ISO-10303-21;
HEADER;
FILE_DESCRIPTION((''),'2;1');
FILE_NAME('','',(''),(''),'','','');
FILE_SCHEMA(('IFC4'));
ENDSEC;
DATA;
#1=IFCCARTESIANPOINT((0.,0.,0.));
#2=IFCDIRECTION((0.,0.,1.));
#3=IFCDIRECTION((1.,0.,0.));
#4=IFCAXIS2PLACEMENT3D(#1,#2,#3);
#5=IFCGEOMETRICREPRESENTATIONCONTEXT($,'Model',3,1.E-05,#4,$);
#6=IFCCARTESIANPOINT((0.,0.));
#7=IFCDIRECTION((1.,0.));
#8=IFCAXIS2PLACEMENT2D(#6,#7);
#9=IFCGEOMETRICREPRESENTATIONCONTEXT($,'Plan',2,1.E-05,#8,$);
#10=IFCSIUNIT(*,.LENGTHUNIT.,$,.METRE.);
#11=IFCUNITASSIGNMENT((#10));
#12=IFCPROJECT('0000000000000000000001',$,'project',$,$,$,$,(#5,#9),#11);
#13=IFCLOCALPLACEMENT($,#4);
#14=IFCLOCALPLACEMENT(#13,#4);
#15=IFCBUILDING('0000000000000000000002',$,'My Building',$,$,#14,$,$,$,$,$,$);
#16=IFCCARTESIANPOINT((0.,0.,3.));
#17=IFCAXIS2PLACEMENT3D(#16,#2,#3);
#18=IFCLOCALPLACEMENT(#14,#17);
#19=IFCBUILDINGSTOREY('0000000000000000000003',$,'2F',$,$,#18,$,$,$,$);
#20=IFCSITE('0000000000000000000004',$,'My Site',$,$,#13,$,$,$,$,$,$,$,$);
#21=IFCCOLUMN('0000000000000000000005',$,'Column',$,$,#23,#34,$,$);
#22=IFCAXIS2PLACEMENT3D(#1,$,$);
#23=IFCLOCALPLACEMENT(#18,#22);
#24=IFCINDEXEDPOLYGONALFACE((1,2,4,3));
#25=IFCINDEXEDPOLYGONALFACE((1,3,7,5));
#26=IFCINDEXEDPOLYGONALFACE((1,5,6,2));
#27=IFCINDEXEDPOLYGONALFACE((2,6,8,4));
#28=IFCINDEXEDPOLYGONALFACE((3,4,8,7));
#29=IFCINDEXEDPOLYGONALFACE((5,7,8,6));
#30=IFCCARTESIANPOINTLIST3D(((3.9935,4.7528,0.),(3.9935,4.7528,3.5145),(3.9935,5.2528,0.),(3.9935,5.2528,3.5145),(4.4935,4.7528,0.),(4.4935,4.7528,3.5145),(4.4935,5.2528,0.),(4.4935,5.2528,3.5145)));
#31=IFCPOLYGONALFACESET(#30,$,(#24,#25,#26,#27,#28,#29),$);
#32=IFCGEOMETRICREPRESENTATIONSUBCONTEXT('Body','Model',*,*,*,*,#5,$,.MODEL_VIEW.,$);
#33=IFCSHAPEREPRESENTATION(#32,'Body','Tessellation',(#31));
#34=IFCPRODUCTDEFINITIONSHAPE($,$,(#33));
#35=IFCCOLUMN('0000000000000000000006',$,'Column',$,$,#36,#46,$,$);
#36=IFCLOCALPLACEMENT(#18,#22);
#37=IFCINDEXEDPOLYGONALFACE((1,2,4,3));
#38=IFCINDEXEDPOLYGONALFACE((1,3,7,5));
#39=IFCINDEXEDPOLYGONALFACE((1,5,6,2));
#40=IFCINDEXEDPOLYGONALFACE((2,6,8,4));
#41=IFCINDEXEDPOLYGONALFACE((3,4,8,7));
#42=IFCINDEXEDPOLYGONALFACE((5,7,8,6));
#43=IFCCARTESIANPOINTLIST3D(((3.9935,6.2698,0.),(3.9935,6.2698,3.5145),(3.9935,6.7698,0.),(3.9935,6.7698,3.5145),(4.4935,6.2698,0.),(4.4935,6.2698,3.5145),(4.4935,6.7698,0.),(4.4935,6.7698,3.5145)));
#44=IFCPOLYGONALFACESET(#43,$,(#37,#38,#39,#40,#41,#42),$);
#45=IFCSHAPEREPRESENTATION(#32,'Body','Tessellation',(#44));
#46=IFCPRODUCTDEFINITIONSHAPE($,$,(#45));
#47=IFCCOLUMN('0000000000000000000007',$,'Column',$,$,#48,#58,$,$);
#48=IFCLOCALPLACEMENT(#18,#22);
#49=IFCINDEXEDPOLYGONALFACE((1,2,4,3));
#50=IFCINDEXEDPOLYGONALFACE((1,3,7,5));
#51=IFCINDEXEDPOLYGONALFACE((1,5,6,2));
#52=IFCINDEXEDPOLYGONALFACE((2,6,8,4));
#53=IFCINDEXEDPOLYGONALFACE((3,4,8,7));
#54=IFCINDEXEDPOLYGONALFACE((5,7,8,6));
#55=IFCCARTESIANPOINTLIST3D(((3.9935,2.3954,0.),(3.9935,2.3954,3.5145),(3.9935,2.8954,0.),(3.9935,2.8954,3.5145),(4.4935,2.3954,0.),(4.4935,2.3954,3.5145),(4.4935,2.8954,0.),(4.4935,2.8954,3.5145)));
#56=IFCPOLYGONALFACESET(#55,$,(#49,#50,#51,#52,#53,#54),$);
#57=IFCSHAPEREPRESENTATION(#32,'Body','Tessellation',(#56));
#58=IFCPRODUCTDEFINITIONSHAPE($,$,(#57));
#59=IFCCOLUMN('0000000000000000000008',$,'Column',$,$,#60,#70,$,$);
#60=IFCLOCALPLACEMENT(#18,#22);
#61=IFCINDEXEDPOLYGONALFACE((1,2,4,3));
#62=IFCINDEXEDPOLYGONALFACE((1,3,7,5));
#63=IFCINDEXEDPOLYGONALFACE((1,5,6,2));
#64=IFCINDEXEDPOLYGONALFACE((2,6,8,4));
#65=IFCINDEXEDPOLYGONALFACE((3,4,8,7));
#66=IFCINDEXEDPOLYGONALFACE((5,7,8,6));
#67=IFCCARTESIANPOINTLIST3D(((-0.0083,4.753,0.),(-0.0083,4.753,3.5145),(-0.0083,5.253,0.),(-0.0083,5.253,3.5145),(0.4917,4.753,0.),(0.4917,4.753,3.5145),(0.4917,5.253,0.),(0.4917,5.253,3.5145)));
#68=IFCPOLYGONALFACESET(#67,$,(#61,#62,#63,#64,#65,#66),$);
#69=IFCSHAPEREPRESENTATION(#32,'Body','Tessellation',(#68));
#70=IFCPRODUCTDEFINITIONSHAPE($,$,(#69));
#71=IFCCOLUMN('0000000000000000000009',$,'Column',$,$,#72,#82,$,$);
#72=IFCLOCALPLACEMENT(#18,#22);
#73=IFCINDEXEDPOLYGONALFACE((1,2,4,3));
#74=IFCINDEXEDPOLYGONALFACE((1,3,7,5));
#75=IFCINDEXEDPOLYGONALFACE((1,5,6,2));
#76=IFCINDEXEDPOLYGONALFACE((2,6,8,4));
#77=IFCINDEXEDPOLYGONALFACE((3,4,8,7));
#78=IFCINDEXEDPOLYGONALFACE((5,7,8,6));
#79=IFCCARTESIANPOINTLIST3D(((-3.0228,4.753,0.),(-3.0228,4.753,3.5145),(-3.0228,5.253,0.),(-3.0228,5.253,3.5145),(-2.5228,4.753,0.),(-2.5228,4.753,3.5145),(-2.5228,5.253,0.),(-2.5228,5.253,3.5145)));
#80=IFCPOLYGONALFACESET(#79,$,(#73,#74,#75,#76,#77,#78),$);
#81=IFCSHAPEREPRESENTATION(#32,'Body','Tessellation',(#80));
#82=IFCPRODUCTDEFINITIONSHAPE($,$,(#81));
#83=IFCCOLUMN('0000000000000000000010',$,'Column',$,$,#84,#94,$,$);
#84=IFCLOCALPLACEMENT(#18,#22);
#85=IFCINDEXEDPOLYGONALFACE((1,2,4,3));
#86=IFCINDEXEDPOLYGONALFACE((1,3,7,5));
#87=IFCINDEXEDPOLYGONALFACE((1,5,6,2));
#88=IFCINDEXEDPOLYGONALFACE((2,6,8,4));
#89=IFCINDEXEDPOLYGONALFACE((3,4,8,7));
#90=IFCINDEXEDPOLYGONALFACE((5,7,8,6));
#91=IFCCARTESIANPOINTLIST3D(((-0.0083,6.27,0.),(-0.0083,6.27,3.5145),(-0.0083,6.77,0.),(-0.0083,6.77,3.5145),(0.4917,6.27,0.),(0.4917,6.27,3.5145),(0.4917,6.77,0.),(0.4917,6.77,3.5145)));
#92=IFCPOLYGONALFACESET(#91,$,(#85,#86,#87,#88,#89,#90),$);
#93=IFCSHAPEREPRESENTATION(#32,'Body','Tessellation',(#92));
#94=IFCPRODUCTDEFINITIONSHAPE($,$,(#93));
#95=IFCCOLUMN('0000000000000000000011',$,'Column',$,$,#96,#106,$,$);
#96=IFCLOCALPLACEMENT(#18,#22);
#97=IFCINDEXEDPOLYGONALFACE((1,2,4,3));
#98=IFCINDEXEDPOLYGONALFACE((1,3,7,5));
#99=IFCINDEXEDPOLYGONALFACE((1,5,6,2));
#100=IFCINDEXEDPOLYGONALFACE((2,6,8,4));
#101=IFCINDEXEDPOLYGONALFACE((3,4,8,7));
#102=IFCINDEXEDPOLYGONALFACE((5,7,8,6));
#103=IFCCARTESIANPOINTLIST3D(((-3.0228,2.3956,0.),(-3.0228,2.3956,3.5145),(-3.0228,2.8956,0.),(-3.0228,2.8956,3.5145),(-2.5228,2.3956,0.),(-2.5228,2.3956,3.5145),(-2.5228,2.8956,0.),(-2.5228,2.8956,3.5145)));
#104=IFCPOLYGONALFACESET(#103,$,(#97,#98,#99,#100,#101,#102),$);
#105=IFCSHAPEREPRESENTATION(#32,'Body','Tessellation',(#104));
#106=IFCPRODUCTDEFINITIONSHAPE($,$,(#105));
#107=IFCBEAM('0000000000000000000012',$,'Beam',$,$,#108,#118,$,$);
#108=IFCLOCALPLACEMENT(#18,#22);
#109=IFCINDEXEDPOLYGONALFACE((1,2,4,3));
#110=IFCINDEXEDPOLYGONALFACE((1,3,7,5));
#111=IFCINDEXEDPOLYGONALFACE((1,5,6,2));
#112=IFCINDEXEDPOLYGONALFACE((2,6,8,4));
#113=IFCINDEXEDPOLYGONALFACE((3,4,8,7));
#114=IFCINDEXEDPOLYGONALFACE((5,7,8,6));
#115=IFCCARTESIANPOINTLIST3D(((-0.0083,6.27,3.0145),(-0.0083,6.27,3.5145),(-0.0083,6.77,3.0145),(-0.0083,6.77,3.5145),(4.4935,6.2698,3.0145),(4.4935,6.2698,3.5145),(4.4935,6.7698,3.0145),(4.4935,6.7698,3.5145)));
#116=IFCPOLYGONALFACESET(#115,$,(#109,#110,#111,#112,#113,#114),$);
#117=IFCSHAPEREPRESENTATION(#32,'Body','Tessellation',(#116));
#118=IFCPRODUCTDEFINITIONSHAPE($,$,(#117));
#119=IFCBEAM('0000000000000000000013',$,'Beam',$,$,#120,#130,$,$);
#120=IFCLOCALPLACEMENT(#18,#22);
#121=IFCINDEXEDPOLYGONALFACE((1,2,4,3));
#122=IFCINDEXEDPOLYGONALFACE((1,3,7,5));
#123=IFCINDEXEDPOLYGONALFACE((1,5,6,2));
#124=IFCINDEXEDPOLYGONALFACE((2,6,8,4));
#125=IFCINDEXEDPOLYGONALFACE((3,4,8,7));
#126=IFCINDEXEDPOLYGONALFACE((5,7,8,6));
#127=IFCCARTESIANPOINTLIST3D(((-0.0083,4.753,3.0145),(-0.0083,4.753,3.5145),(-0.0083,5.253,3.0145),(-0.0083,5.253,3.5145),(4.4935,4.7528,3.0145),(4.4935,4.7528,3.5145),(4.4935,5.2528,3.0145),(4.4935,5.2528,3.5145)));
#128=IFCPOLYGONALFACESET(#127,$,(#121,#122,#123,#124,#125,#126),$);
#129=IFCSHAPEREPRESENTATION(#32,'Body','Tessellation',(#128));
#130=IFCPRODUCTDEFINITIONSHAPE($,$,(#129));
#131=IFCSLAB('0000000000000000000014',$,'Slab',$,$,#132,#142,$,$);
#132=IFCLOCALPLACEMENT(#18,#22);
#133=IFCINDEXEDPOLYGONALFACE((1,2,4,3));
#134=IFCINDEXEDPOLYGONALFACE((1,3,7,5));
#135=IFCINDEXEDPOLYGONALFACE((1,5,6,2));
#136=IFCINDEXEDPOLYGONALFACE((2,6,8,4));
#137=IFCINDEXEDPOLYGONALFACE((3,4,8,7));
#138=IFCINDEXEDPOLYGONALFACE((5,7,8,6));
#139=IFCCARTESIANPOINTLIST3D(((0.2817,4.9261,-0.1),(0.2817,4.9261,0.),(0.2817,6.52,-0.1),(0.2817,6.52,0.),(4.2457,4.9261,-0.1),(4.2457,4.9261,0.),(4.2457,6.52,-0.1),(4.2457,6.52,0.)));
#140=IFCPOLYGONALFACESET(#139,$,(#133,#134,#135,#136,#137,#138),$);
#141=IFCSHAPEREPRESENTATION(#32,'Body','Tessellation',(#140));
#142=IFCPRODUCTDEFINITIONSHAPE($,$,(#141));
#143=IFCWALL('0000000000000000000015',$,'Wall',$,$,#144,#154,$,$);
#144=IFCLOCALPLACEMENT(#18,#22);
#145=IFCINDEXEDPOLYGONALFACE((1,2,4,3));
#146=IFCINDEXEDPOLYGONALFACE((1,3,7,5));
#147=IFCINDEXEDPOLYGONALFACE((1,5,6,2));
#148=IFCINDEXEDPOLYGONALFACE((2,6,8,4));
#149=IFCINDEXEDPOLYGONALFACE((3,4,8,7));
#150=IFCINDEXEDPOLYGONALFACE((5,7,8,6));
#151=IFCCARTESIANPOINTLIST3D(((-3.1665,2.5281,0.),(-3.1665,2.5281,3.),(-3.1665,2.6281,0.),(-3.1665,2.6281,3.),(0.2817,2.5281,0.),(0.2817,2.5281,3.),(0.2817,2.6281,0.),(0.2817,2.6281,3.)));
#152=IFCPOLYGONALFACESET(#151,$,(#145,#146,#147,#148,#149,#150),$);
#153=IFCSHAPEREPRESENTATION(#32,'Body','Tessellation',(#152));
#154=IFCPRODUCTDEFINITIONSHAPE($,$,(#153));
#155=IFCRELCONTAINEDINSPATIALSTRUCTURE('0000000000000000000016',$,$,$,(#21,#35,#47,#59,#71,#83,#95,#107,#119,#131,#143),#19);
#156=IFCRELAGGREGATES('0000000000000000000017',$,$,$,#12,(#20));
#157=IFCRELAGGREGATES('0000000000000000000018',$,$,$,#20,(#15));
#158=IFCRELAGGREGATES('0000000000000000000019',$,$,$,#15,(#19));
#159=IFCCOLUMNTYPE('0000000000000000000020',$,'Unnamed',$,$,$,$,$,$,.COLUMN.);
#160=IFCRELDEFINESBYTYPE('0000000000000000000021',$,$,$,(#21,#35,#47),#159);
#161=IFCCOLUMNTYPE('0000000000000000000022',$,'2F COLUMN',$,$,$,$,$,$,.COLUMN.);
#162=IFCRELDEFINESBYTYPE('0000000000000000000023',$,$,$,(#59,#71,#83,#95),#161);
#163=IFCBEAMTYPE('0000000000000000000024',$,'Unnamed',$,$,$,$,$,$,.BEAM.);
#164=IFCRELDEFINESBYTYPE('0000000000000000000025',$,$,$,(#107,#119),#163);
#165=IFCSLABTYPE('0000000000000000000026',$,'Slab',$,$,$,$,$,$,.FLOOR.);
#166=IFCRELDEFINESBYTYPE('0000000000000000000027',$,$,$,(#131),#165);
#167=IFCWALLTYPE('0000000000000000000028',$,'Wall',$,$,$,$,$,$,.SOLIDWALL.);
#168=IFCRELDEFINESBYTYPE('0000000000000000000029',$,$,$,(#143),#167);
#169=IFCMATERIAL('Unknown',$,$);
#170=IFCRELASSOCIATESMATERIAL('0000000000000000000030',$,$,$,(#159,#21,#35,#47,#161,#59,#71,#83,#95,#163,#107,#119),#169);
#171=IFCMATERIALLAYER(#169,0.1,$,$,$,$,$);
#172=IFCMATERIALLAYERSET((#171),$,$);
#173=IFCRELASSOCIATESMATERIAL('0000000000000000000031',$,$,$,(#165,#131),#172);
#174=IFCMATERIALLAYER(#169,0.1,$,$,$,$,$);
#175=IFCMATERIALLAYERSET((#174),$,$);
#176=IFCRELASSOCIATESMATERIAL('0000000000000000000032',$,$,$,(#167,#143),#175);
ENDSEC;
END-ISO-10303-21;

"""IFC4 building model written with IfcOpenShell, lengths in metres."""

from ifc_helpers import new_model, si_unit, frame, origin_with_axes, origin_2d_with_axis, place, context, subcontext, project, spatial, line, indexed_curve, rectangle, outline, extrude, material, layer, layer_set, layer_usage, material_profile, profile_set, profile_usage, type_object, element, save


model = new_model("IFC4")

# Units and contexts
model_context = context("Model", 3, precision=1e-05, world=origin_with_axes())
plan_context = context("Plan", 2, precision=1e-05, world=origin_2d_with_axis())
body_context_1 = subcontext(model_context, "Body", "Model", "MODEL_VIEW")
ifc_project = project(units=[si_unit("LENGTHUNIT", "METRE")], contexts=[model_context, plan_context])

# Site, building, storey
site_placement = place(None, origin_with_axes())
site = spatial("IfcSite", under=ifc_project, at=site_placement, Name="My Site")
building_placement = place(site_placement, origin_with_axes())
building = spatial("IfcBuilding", under=site, at=building_placement, Name="My Building")
storey_placement = place(building_placement, frame((0.0, 0.0, 3.0), z_axis=(0.0, 0.0, 1.0), x_axis=(1.0, 0.0, 0.0)))
storey = spatial("IfcBuildingStorey", under=building, at=storey_placement, Name="2F")

# Columns
ifc_material = material(Name="Unknown")
ifc_material_profile_1 = material_profile(ifc_material, rectangle(XDim=0.5, YDim=0.5))
ifc_profile_set_1 = profile_set([ifc_material_profile_1])
ifc_profile_usage_1 = profile_usage(ifc_profile_set_1, cardinal=7)
column_type_1 = type_object("IfcColumnType", Name="Unnamed", PredefinedType="COLUMN", material=ifc_profile_set_1)
column_1_placement = place(storey_placement, frame((4.4935, 5.2528, 0.0), z_axis=(0.0, 0.0, 1.0), x_axis=(1.0, 0.0, 0.0)))
element("IfcColumn", 1, at=column_1_placement, inside=storey, type_object=column_type_1, material=ifc_profile_usage_1, Name="Column", context=body_context_1, shape_type="SweptSolid", body=[
    extrude(rectangle(XDim=0.5, YDim=0.5), frame((-0.25, -0.25, 0.0), z_axis=(0.0, 0.0, 1.0), x_axis=(1.0, 0.0, 0.0)), (0.0, 0.0, 1.0), 3.5145),
])
ifc_profile_usage_2 = profile_usage(ifc_profile_set_1, cardinal=7)
column_2_placement = place(storey_placement, frame((4.4935, 6.7698, 0.0), z_axis=(0.0, 0.0, 1.0), x_axis=(1.0, 0.0, 0.0)))
element("IfcColumn", 2, at=column_2_placement, inside=storey, type_object=column_type_1, material=ifc_profile_usage_2, Name="Column", context=body_context_1, shape_type="SweptSolid", body=[
    extrude(rectangle(XDim=0.5, YDim=0.5), frame((-0.25, -0.25, 0.0), z_axis=(0.0, 0.0, 1.0), x_axis=(1.0, 0.0, 0.0)), (0.0, 0.0, 1.0), 3.5145),
])
ifc_profile_usage_3 = profile_usage(ifc_profile_set_1, cardinal=7)
column_3_placement = place(storey_placement, frame((4.4935, 2.8954, 0.0), z_axis=(0.0, 0.0, 1.0), x_axis=(1.0, 0.0, 0.0)))
element("IfcColumn", 3, at=column_3_placement, inside=storey, type_object=column_type_1, material=ifc_profile_usage_3, Name="Column", context=body_context_1, shape_type="SweptSolid", body=[
    extrude(rectangle(XDim=0.5, YDim=0.5), frame((-0.25, -0.25, 0.0), z_axis=(0.0, 0.0, 1.0), x_axis=(1.0, 0.0, 0.0)), (0.0, 0.0, 1.0), 3.5145),
])
ifc_material_profile_2 = material_profile(ifc_material, rectangle(XDim=0.5, YDim=0.5))
ifc_profile_set_2 = profile_set([ifc_material_profile_2])
ifc_profile_usage_4 = profile_usage(ifc_profile_set_2, cardinal=7)
column_type_2 = type_object("IfcColumnType", Name="2F COLUMN", PredefinedType="COLUMN", material=ifc_profile_set_2)
column_4_placement = place(storey_placement, frame((0.4917, 5.253, 0.0), z_axis=(0.0, 0.0, 1.0), x_axis=(1.0, 0.0, 0.0)))
element("IfcColumn", 4, at=column_4_placement, inside=storey, type_object=column_type_2, material=ifc_profile_usage_4, Name="Column", context=body_context_1, shape_type="SweptSolid", body=[
    extrude(rectangle(XDim=0.5, YDim=0.5), frame((-0.25, -0.25, 0.0), z_axis=(0.0, 0.0, 1.0), x_axis=(1.0, 0.0, 0.0)), (0.0, 0.0, 1.0), 3.5145),
])
ifc_profile_usage_5 = profile_usage(ifc_profile_set_2, cardinal=7)
column_5_placement = place(storey_placement, frame((-2.5228, 5.253, 0.0), z_axis=(0.0, 0.0, 1.0), x_axis=(1.0, 0.0, 0.0)))
element("IfcColumn", 5, at=column_5_placement, inside=storey, type_object=column_type_2, material=ifc_profile_usage_5, Name="Column", context=body_context_1, shape_type="SweptSolid", body=[
    extrude(rectangle(XDim=0.5, YDim=0.5), frame((-0.25, -0.25, 0.0), z_axis=(0.0, 0.0, 1.0), x_axis=(1.0, 0.0, 0.0)), (0.0, 0.0, 1.0), 3.5145),
])
ifc_profile_usage_6 = profile_usage(ifc_profile_set_2, cardinal=7)
column_6_placement = place(storey_placement, frame((0.4917, 6.77, 0.0), z_axis=(0.0, 0.0, 1.0), x_axis=(1.0, 0.0, 0.0)))
element("IfcColumn", 6, at=column_6_placement, inside=storey, type_object=column_type_2, material=ifc_profile_usage_6, Name="Column", context=body_context_1, shape_type="SweptSolid", body=[
    extrude(rectangle(XDim=0.5, YDim=0.5), frame((-0.25, -0.25, 0.0), z_axis=(0.0, 0.0, 1.0), x_axis=(1.0, 0.0, 0.0)), (0.0, 0.0, 1.0), 3.5145),
])
ifc_profile_usage_7 = profile_usage(ifc_profile_set_2, cardinal=7)
column_7_placement = place(storey_placement, frame((-2.5228, 2.8956, 0.0), z_axis=(0.0, 0.0, 1.0), x_axis=(1.0, 0.0, 0.0)))
element("IfcColumn", 7, at=column_7_placement, inside=storey, type_object=column_type_2, material=ifc_profile_usage_7, Name="Column", context=body_context_1, shape_type="SweptSolid", body=[
    extrude(rectangle(XDim=0.5, YDim=0.5), frame((-0.25, -0.25, 0.0), z_axis=(0.0, 0.0, 1.0), x_axis=(1.0, 0.0, 0.0)), (0.0, 0.0, 1.0), 3.5145),
])

# Beams
ifc_material_profile_3 = material_profile(ifc_material, rectangle(XDim=0.5, YDim=0.5))
ifc_profile_set_3 = profile_set([ifc_material_profile_3])
ifc_profile_usage_8 = profile_usage(ifc_profile_set_3, cardinal=7)
beam_type = type_object("IfcBeamType", Name="Unnamed", PredefinedType="BEAM", material=ifc_profile_set_3)
beam_1_placement = place(storey_placement, frame((-0.0083, 6.77, 3.5145), z_axis=(1.0, -0.000042, 0.0), x_axis=(0.000042, 1.0, 0.0)))
element("IfcBeam", 8, at=beam_1_placement, inside=storey, type_object=beam_type, material=ifc_profile_usage_8, Name="Beam", context=body_context_1, shape_type="SweptSolid", body=[
    extrude(rectangle(XDim=0.5, YDim=0.5), frame((-0.25, -0.25, 0.0), z_axis=(0.0, 0.0, 1.0), x_axis=(1.0, 0.0, 0.0)), (0.0, 0.0, 1.0), 4.5018),
])
ifc_profile_usage_9 = profile_usage(ifc_profile_set_3, cardinal=7)
beam_2_placement = place(storey_placement, frame((-0.0083, 5.253, 3.5145), z_axis=(1.0, -0.000042, 0.0), x_axis=(0.000042, 1.0, 0.0)))
element("IfcBeam", 9, at=beam_2_placement, inside=storey, type_object=beam_type, material=ifc_profile_usage_9, Name="Beam", context=body_context_1, shape_type="SweptSolid", body=[
    extrude(rectangle(XDim=0.5, YDim=0.5), frame((-0.25, -0.25, 0.0), z_axis=(0.0, 0.0, 1.0), x_axis=(1.0, 0.0, 0.0)), (0.0, 0.0, 1.0), 4.5018),
])

# Slab
ifc_layer_1 = layer(ifc_material, 0.1)
ifc_layer_set_1 = layer_set([ifc_layer_1])
ifc_layer_usage_1 = layer_usage(ifc_layer_set_1, "AXIS3", "POSITIVE", -0.1)
slab_type = type_object("IfcSlabType", Name="Slab", PredefinedType="FLOOR", material=ifc_layer_set_1)
slab_placement = place(storey_placement, frame((4.2457, 6.52, 0.0), z_axis=(0.0, 0.0, 1.0), x_axis=(1.0, 0.0, 0.0)))
element("IfcSlab", 10, at=slab_placement, inside=storey, type_object=slab_type, material=ifc_layer_usage_1, Name="Slab", context=body_context_1, shape_type="SweptSolid", body=[
    extrude(outline(indexed_curve([(0.0, 0.0), (-3.964, 0.0), (-3.964, -1.5939), (0.0, -1.5939), (0.0, 0.0)])), frame((0.0, 0.0, -0.1), z_axis=(0.0, 0.0, 1.0), x_axis=(1.0, 0.0, 0.0)), (0.0, 0.0, 1.0), 0.1),
])

# Wall
ifc_layer_2 = layer(ifc_material, 0.1)
ifc_layer_set_2 = layer_set([ifc_layer_2])
ifc_layer_usage_2 = layer_usage(ifc_layer_set_2, "AXIS2", "POSITIVE", 0.0)
wall_type_1 = type_object("IfcWallType", Name="Wall", PredefinedType="SOLIDWALL", material=ifc_layer_set_2)
wall_1_placement = place(storey_placement, frame((0.2817, 2.6281, 0.0), z_axis=(0.0, 0.0, 1.0), x_axis=(-1.0, 0.0, 0.0)))
element("IfcWall", 11, at=wall_1_placement, inside=storey, type_object=wall_type_1, material=ifc_layer_usage_2, Name="Wall", context=body_context_1, shape_type="SweptSolid", body=[
    extrude(outline(indexed_curve([(0.0, 0.0), (0.0, 0.1), (3.4482, 0.1), (3.4482, 0.0)], segments=[line(1, 2, 3, 4, 1)])), origin_with_axes(), (0.0, 0.0, 1.0), 3.0),
])

save(model, "model.ifc")
